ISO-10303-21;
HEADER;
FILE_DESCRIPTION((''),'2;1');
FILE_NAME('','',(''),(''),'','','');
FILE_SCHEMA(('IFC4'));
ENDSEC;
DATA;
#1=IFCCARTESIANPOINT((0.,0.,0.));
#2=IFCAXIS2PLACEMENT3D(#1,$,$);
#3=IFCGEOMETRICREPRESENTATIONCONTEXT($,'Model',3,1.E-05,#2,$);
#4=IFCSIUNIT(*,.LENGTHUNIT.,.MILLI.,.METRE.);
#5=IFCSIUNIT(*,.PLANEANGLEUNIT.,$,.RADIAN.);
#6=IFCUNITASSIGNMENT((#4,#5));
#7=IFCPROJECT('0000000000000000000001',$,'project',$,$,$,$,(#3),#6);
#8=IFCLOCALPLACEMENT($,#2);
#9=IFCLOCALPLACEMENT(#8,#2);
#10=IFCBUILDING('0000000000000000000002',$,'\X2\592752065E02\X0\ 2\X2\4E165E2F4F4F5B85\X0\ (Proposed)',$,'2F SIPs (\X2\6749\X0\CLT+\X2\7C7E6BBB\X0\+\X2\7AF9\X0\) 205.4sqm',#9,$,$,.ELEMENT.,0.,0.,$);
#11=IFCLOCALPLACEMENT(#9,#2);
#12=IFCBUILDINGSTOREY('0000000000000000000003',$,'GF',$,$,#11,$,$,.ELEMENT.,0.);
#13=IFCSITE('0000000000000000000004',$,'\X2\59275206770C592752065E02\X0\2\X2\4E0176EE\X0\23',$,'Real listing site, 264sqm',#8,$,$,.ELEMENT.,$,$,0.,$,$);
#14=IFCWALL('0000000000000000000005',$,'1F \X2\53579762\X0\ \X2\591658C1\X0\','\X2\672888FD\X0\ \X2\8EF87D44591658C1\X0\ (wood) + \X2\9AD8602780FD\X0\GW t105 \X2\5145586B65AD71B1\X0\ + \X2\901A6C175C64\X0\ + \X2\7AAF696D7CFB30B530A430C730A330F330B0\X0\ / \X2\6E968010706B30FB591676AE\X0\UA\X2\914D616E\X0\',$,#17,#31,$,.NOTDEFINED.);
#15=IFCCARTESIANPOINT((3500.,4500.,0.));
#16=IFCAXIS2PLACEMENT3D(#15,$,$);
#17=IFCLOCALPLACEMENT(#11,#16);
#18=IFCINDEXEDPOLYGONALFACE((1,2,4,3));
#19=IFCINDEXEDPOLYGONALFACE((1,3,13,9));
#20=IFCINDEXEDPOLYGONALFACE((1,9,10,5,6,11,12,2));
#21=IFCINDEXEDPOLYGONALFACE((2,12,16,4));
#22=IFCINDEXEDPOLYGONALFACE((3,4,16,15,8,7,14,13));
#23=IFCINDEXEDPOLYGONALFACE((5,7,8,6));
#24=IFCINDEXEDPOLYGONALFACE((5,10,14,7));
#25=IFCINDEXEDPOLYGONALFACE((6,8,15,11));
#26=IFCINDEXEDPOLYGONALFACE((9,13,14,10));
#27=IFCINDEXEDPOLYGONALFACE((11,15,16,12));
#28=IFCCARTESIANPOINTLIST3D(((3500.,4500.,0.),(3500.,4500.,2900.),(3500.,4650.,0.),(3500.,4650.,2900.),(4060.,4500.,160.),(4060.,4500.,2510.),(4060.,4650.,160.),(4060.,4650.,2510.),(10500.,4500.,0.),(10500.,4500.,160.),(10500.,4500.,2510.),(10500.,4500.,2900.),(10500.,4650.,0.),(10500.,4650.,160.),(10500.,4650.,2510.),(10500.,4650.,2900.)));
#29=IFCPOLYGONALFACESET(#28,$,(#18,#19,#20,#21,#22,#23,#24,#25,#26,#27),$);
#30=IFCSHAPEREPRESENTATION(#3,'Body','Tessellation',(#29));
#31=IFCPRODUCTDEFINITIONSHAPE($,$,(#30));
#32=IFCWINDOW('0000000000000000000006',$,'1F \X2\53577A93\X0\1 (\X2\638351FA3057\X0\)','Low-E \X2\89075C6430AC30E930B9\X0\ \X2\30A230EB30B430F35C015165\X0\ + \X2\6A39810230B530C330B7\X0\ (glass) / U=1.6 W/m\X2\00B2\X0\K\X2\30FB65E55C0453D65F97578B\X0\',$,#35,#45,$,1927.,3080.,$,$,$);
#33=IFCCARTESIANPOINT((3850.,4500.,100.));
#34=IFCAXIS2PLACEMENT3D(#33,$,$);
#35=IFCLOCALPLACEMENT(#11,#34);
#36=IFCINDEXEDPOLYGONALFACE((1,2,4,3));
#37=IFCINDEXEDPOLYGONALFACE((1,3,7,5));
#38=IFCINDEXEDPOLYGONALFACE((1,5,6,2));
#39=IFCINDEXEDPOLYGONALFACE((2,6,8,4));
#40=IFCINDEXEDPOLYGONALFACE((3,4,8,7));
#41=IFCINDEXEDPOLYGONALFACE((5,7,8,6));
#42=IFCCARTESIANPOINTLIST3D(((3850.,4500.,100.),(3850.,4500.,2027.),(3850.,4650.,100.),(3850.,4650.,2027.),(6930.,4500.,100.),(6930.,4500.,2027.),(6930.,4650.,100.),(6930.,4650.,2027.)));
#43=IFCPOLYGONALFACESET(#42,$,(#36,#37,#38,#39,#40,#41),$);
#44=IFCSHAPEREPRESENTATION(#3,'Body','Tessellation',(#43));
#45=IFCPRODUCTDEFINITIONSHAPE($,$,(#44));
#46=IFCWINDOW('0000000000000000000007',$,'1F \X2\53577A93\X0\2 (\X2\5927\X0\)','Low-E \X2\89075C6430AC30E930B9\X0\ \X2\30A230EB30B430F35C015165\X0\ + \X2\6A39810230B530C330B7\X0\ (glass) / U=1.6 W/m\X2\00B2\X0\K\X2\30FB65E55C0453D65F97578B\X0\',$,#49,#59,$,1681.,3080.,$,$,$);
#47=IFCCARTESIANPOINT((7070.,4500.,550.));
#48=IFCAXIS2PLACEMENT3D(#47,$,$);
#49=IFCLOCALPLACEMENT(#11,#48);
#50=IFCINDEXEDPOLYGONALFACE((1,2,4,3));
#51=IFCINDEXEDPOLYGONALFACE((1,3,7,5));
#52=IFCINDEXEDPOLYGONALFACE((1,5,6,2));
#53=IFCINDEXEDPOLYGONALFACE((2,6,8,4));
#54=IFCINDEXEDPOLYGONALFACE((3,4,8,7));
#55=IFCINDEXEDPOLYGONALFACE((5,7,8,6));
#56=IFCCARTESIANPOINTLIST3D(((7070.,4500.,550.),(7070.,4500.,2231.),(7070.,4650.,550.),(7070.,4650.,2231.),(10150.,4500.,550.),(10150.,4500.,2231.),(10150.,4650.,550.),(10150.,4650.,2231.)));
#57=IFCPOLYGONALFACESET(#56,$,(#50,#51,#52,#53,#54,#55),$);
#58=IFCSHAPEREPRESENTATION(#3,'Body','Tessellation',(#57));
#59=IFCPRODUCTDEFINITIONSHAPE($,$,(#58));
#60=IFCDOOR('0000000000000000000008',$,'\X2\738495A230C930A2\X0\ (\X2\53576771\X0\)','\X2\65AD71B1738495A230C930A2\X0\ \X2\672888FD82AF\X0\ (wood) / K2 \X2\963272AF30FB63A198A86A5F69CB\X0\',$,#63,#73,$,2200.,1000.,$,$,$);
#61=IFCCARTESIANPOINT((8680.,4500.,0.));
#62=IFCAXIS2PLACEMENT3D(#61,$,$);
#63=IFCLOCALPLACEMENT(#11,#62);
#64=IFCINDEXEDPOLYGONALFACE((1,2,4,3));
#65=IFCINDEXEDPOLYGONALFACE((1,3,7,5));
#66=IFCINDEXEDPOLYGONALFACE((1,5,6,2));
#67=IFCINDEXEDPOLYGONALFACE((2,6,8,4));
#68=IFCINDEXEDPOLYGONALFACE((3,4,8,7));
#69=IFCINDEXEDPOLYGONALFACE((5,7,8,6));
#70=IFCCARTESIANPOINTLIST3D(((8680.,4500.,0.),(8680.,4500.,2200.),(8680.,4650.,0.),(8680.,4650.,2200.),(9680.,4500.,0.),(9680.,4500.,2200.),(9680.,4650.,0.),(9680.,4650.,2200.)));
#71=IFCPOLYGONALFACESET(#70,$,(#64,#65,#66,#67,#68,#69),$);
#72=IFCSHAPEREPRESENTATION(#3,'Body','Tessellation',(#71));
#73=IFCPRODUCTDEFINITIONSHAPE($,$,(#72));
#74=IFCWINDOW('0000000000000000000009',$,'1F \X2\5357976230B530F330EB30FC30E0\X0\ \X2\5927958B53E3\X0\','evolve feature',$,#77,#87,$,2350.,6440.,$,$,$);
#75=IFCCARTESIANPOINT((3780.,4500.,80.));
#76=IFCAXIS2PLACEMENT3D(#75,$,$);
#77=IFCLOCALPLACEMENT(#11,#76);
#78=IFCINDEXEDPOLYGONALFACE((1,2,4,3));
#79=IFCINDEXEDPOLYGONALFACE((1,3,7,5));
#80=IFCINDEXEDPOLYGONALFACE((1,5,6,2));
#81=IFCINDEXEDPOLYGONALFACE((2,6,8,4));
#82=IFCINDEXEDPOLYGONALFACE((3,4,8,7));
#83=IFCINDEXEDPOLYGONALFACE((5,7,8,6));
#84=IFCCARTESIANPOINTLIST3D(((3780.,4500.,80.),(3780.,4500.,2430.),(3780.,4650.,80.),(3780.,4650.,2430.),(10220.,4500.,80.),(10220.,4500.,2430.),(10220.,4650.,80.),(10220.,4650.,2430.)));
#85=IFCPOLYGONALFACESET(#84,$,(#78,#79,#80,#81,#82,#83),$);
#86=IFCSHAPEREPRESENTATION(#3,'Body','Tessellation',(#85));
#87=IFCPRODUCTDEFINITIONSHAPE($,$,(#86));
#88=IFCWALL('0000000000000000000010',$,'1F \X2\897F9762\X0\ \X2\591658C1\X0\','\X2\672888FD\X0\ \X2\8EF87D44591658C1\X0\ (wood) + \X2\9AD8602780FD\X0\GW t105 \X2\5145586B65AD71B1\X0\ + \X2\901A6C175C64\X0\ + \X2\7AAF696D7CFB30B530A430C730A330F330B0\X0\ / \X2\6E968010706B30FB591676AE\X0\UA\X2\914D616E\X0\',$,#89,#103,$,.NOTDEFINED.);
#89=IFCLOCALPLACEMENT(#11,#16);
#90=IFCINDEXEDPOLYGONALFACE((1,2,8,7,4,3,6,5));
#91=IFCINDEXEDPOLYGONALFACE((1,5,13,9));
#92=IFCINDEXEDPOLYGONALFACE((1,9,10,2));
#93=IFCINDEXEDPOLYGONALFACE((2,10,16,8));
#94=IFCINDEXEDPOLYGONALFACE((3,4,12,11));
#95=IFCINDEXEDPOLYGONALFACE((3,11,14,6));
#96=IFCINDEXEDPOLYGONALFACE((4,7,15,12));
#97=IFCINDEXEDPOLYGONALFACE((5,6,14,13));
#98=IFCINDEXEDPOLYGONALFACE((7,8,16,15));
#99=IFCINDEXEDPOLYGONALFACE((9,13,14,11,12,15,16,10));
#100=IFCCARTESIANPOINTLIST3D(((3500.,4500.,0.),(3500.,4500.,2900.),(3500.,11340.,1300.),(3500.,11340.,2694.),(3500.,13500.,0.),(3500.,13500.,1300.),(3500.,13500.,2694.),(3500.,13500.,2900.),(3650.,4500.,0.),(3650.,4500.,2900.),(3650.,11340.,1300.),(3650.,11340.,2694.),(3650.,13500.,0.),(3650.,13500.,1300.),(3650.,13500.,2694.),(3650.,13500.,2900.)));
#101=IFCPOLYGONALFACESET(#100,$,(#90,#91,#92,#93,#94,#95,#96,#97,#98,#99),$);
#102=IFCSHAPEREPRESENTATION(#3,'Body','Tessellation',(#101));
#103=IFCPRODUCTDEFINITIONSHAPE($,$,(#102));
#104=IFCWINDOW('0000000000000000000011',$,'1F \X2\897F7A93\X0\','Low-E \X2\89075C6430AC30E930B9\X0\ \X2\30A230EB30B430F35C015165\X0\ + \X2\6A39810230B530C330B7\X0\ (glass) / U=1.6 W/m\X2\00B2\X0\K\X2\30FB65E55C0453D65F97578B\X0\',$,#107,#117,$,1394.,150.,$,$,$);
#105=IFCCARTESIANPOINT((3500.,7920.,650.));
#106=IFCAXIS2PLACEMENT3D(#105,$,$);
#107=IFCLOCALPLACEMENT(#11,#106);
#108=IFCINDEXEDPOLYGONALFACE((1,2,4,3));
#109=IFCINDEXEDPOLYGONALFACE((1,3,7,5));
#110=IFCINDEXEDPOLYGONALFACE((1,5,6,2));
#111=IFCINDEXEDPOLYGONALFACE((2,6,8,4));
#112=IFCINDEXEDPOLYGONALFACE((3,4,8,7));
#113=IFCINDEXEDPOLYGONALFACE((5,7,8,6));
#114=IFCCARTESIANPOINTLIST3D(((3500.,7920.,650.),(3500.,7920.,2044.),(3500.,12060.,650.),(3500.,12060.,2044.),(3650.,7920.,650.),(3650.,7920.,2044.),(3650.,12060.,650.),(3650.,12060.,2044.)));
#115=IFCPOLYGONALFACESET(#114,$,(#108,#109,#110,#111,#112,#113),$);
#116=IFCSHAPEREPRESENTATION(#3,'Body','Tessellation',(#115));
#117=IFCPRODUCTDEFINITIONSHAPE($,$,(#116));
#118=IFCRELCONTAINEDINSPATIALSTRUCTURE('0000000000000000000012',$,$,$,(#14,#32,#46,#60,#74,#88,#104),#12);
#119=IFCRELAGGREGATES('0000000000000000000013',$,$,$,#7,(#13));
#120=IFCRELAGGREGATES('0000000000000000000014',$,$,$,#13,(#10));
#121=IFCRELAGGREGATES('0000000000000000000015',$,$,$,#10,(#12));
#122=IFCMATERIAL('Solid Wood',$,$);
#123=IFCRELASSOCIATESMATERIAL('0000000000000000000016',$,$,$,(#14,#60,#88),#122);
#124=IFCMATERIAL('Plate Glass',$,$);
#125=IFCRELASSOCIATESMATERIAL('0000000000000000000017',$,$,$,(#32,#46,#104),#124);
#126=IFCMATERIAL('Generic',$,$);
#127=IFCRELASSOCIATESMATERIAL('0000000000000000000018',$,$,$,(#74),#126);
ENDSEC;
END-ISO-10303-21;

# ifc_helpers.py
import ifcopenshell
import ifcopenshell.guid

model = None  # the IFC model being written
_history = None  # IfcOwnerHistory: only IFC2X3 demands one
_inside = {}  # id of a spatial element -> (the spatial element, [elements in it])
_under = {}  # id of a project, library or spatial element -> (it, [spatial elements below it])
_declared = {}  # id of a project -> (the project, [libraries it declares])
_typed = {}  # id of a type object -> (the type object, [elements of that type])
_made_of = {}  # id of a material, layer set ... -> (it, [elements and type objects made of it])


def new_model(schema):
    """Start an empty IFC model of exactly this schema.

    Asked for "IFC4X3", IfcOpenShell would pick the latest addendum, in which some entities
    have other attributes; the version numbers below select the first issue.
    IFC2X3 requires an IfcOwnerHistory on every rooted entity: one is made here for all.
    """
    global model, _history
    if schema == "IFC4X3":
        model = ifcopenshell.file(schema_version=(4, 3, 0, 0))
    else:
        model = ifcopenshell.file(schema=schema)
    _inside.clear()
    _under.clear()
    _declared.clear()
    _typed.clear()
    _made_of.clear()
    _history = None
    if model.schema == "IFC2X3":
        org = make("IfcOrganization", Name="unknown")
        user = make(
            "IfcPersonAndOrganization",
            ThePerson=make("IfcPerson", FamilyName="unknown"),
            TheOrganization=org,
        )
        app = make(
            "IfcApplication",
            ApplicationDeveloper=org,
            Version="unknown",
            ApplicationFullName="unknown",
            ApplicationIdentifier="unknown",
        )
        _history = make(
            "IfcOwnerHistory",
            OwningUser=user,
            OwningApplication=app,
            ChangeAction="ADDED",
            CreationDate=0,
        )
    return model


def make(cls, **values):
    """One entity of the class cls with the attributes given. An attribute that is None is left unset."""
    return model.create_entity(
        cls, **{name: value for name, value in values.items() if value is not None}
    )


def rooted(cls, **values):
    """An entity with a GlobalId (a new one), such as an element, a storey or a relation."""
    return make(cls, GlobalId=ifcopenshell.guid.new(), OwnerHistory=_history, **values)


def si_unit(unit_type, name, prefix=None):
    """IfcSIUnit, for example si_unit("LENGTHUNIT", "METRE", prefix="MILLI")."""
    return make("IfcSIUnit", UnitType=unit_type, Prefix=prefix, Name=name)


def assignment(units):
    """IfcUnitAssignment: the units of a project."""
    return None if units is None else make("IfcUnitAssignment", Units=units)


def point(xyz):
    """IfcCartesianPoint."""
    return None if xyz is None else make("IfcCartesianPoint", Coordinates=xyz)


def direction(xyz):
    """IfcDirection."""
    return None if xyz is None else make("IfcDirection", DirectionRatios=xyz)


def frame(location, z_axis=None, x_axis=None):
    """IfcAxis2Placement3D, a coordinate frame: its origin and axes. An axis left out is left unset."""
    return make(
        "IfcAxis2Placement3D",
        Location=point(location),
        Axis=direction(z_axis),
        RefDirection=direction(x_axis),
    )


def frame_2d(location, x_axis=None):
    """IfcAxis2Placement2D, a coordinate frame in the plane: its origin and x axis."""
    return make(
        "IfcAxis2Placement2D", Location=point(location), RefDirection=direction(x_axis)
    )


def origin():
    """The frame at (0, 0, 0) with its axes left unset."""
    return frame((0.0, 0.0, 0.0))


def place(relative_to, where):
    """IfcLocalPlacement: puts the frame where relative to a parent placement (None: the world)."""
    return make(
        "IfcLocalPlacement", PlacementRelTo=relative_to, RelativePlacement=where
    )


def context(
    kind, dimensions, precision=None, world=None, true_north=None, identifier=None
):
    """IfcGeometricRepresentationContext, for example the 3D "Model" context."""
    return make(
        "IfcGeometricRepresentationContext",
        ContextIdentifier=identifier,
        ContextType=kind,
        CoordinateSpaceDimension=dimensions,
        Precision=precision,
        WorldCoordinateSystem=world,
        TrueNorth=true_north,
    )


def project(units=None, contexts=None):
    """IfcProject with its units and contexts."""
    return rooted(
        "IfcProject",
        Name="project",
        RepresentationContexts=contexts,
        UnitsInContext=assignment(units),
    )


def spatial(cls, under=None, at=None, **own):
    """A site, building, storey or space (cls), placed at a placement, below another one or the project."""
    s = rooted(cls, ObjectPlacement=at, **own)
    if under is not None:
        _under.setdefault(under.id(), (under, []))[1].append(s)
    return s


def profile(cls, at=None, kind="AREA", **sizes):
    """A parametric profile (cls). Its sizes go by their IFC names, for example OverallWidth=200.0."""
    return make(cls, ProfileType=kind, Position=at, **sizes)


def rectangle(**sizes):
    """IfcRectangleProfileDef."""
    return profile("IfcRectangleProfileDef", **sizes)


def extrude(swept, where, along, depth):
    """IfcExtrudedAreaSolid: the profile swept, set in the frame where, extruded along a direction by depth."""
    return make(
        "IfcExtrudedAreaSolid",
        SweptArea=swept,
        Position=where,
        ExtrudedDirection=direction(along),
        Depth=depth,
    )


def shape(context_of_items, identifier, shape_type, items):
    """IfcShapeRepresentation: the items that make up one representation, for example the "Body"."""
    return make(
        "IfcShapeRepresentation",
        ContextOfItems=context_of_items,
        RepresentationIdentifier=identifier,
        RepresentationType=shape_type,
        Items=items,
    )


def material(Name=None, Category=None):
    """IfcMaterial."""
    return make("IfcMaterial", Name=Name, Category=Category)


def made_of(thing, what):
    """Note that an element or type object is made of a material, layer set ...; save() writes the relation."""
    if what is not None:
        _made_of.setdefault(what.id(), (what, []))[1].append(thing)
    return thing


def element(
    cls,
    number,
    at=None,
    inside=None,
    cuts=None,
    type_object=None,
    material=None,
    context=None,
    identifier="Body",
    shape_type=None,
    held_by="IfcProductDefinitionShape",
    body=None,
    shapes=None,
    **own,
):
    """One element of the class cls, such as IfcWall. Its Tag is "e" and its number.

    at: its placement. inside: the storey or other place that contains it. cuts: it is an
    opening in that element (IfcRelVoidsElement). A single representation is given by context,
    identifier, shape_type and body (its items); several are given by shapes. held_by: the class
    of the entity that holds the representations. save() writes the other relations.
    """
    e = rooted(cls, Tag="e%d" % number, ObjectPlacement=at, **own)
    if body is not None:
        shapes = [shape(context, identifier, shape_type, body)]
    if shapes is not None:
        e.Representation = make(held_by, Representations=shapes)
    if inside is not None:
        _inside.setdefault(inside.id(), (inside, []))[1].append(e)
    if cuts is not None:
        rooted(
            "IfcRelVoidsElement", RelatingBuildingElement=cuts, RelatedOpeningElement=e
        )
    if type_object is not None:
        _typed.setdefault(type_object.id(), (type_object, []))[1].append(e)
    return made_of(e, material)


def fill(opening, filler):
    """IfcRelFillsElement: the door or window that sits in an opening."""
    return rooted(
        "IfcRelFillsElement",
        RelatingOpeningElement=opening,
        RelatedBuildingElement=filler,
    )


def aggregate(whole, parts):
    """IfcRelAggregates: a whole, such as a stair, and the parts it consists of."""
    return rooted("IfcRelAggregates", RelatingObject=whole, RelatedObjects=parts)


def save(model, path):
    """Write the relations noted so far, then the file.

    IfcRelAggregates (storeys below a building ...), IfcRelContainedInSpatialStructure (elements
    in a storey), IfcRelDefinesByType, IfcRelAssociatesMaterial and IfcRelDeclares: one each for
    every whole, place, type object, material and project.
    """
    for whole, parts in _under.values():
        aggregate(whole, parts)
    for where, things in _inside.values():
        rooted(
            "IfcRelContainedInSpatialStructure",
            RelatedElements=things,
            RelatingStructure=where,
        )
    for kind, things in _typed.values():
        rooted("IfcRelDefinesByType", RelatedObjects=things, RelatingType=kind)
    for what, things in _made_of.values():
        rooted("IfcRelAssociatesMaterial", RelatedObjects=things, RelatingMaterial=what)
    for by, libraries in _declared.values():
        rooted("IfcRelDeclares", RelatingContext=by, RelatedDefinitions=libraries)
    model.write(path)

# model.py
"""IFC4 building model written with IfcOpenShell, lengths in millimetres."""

from ifc_helpers import new_model, si_unit, frame, frame_2d, origin, place, context, project, spatial, rectangle, extrude, material, element, fill, save


model = new_model("IFC4")

# Units and contexts
model_context = context("Model", 3, precision=1e-05, world=origin())
ifc_project = project(units=[si_unit("LENGTHUNIT", "METRE", prefix="MILLI"), si_unit("PLANEANGLEUNIT", "RADIAN")], contexts=[model_context])

# Site, building, storey
site_placement = place(None, origin())
site = spatial("IfcSite", under=ifc_project, at=site_placement, Name="大分県大分市2丁目23", ObjectType="Real listing site, 264sqm", CompositionType="ELEMENT", RefElevation=0.0)
building_placement = place(site_placement, origin())
building = spatial("IfcBuilding", under=site, at=building_placement, Name="大分市 2世帯住宅 (Proposed)", ObjectType="2F SIPs (杉CLT+籾殻+竹) 205.4sqm", CompositionType="ELEMENT", ElevationOfRefHeight=0.0, ElevationOfTerrain=0.0)
storey_placement = place(building_placement, origin())
storey = spatial("IfcBuildingStorey", under=building, at=storey_placement, Name="GF", CompositionType="ELEMENT", Elevation=0.0)

# Shared definitions
ifc_material_1 = material(Name="Solid Wood")

# Wall, openings, windows, door
wall_1_placement = place(storey_placement, frame((3500.0, 4500.0, 0.0)))
wall_1 = element("IfcWall", 1, at=wall_1_placement, inside=storey, material=ifc_material_1, Name="1F 南面 外壁", Description="木製 軸組外壁 (wood) + 高性能GW t105 充填断熱 + 通気層 + 窯業系サイディング / 準耐火・外皮UA配慮", PredefinedType="NOTDEFINED", context=model_context, shape_type="SweptSolid", body=[
    extrude(rectangle(XDim=7000.0, YDim=150.0, at=frame_2d((3500.0, 75.0))), frame((3500.0, 4500.0, 0.0)), (0.0, 0.0, 1.0), 2900.0),
])
opening_1_placement = place(storey_placement, frame((3850.0, 4500.0, 100.0)))
opening_1 = element("IfcOpeningElement", 2, at=opening_1_placement, cuts=wall_1, PredefinedType="NOTDEFINED", context=model_context, shape_type="SweptSolid", body=[
    extrude(rectangle(XDim=3080.0, YDim=150.0, at=frame_2d((1540.0, 75.0))), frame((3850.0, 4500.0, 100.0)), (0.0, 0.0, 1.0), 1927.0),
])
opening_2_placement = place(storey_placement, frame((7070.0, 4500.0, 550.0)))
opening_2 = element("IfcOpeningElement", 3, at=opening_2_placement, cuts=wall_1, PredefinedType="NOTDEFINED", context=model_context, shape_type="SweptSolid", body=[
    extrude(rectangle(XDim=3080.0, YDim=150.0, at=frame_2d((1540.0, 75.0))), frame((7070.0, 4500.0, 550.0)), (0.0, 0.0, 1.0), 1681.0),
])
opening_3_placement = place(storey_placement, frame((8680.0, 4500.0, 0.0)))
opening_3 = element("IfcOpeningElement", 4, at=opening_3_placement, cuts=wall_1, PredefinedType="NOTDEFINED", context=model_context, shape_type="SweptSolid", body=[
    extrude(rectangle(XDim=1000.0, YDim=150.0, at=frame_2d((500.0, 75.0))), frame((8680.0, 4500.0, 0.0)), (0.0, 0.0, 1.0), 2200.0),
])
opening_4_placement = place(storey_placement, frame((3780.0, 4500.0, 80.0)))
opening_4 = element("IfcOpeningElement", 5, at=opening_4_placement, cuts=wall_1, PredefinedType="NOTDEFINED", context=model_context, shape_type="SweptSolid", body=[
    extrude(rectangle(XDim=6440.0, YDim=150.0, at=frame_2d((3220.0, 75.0))), frame((3780.0, 4500.0, 80.0)), (0.0, 0.0, 1.0), 2350.0),
])
ifc_material_2 = material(Name="Plate Glass")
window_1_placement = place(storey_placement, frame((3850.0, 4500.0, 100.0)))
window_1 = element("IfcWindow", 6, at=window_1_placement, inside=storey, material=ifc_material_2, Name="1F 南窓1 (掃出し)", Description="Low-E 複層ガラス アルゴン封入 + 樹脂サッシ (glass) / U=1.6 W/m²K・日射取得型", OverallHeight=1927.0, OverallWidth=3080.0, context=model_context, shape_type="SweptSolid", body=[
    extrude(rectangle(XDim=3080.0, YDim=150.0, at=frame_2d((1540.0, 75.0))), frame((3850.0, 4500.0, 100.0)), (0.0, 0.0, 1.0), 1927.0),
])
fill(opening_1, window_1)
window_2_placement = place(storey_placement, frame((7070.0, 4500.0, 550.0)))
window_2 = element("IfcWindow", 7, at=window_2_placement, inside=storey, material=ifc_material_2, Name="1F 南窓2 (大)", Description="Low-E 複層ガラス アルゴン封入 + 樹脂サッシ (glass) / U=1.6 W/m²K・日射取得型", OverallHeight=1681.0, OverallWidth=3080.0, context=model_context, shape_type="SweptSolid", body=[
    extrude(rectangle(XDim=3080.0, YDim=150.0, at=frame_2d((1540.0, 75.0))), frame((7070.0, 4500.0, 550.0)), (0.0, 0.0, 1.0), 1681.0),
])
fill(opening_2, window_2)
door_placement = place(storey_placement, frame((8680.0, 4500.0, 0.0)))
door = element("IfcDoor", 8, at=door_placement, inside=storey, material=ifc_material_1, Name="玄関ドア (南東)", Description="断熱玄関ドア 木製芯 (wood) / K2 防犯・採風機構", OverallHeight=2200.0, OverallWidth=1000.0, context=model_context, shape_type="SweptSolid", body=[
    extrude(rectangle(XDim=1000.0, YDim=150.0, at=frame_2d((500.0, 75.0))), frame((8680.0, 4500.0, 0.0)), (0.0, 0.0, 1.0), 2200.0),
])
fill(opening_3, door)
ifc_material_3 = material(Name="Generic")
window_3_placement = place(storey_placement, frame((3780.0, 4500.0, 80.0)))
window_3 = element("IfcWindow", 9, at=window_3_placement, inside=storey, material=ifc_material_3, Name="1F 南面サンルーム 大開口", Description="evolve feature", OverallHeight=2350.0, OverallWidth=6440.0, context=model_context, shape_type="SweptSolid", body=[
    extrude(rectangle(XDim=6440.0, YDim=150.0, at=frame_2d((3220.0, 75.0))), frame((3780.0, 4500.0, 80.0)), (0.0, 0.0, 1.0), 2350.0),
])
fill(opening_4, window_3)

# Wall, opening, window
wall_2_placement = place(storey_placement, frame((3500.0, 4500.0, 0.0)))
wall_2 = element("IfcWall", 10, at=wall_2_placement, inside=storey, material=ifc_material_1, Name="1F 西面 外壁", Description="木製 軸組外壁 (wood) + 高性能GW t105 充填断熱 + 通気層 + 窯業系サイディング / 準耐火・外皮UA配慮", PredefinedType="NOTDEFINED", context=model_context, shape_type="SweptSolid", body=[
    extrude(rectangle(XDim=150.0, YDim=9000.0, at=frame_2d((75.0, 4500.0))), frame((3500.0, 4500.0, 0.0)), (0.0, 0.0, 1.0), 2900.0),
])
opening_5_placement = place(storey_placement, frame((3500.0, 7920.0, 650.0)))
opening_5 = element("IfcOpeningElement", 11, at=opening_5_placement, cuts=wall_2, PredefinedType="NOTDEFINED", context=model_context, shape_type="SweptSolid", body=[
    extrude(rectangle(XDim=150.0, YDim=4140.0, at=frame_2d((75.0, 2070.0))), frame((3500.0, 7920.0, 650.0)), (0.0, 0.0, 1.0), 1394.0),
])
window_4_placement = place(storey_placement, frame((3500.0, 7920.0, 650.0)))
window_4 = element("IfcWindow", 12, at=window_4_placement, inside=storey, material=ifc_material_2, Name="1F 西窓", Description="Low-E 複層ガラス アルゴン封入 + 樹脂サッシ (glass) / U=1.6 W/m²K・日射取得型", OverallHeight=1394.0, OverallWidth=150.0, context=model_context, shape_type="SweptSolid", body=[
    extrude(rectangle(XDim=150.0, YDim=4140.0, at=frame_2d((75.0, 2070.0))), frame((3500.0, 7920.0, 650.0)), (0.0, 0.0, 1.0), 1394.0),
])
fill(opening_5, window_4)

save(model, "model.ifc")
